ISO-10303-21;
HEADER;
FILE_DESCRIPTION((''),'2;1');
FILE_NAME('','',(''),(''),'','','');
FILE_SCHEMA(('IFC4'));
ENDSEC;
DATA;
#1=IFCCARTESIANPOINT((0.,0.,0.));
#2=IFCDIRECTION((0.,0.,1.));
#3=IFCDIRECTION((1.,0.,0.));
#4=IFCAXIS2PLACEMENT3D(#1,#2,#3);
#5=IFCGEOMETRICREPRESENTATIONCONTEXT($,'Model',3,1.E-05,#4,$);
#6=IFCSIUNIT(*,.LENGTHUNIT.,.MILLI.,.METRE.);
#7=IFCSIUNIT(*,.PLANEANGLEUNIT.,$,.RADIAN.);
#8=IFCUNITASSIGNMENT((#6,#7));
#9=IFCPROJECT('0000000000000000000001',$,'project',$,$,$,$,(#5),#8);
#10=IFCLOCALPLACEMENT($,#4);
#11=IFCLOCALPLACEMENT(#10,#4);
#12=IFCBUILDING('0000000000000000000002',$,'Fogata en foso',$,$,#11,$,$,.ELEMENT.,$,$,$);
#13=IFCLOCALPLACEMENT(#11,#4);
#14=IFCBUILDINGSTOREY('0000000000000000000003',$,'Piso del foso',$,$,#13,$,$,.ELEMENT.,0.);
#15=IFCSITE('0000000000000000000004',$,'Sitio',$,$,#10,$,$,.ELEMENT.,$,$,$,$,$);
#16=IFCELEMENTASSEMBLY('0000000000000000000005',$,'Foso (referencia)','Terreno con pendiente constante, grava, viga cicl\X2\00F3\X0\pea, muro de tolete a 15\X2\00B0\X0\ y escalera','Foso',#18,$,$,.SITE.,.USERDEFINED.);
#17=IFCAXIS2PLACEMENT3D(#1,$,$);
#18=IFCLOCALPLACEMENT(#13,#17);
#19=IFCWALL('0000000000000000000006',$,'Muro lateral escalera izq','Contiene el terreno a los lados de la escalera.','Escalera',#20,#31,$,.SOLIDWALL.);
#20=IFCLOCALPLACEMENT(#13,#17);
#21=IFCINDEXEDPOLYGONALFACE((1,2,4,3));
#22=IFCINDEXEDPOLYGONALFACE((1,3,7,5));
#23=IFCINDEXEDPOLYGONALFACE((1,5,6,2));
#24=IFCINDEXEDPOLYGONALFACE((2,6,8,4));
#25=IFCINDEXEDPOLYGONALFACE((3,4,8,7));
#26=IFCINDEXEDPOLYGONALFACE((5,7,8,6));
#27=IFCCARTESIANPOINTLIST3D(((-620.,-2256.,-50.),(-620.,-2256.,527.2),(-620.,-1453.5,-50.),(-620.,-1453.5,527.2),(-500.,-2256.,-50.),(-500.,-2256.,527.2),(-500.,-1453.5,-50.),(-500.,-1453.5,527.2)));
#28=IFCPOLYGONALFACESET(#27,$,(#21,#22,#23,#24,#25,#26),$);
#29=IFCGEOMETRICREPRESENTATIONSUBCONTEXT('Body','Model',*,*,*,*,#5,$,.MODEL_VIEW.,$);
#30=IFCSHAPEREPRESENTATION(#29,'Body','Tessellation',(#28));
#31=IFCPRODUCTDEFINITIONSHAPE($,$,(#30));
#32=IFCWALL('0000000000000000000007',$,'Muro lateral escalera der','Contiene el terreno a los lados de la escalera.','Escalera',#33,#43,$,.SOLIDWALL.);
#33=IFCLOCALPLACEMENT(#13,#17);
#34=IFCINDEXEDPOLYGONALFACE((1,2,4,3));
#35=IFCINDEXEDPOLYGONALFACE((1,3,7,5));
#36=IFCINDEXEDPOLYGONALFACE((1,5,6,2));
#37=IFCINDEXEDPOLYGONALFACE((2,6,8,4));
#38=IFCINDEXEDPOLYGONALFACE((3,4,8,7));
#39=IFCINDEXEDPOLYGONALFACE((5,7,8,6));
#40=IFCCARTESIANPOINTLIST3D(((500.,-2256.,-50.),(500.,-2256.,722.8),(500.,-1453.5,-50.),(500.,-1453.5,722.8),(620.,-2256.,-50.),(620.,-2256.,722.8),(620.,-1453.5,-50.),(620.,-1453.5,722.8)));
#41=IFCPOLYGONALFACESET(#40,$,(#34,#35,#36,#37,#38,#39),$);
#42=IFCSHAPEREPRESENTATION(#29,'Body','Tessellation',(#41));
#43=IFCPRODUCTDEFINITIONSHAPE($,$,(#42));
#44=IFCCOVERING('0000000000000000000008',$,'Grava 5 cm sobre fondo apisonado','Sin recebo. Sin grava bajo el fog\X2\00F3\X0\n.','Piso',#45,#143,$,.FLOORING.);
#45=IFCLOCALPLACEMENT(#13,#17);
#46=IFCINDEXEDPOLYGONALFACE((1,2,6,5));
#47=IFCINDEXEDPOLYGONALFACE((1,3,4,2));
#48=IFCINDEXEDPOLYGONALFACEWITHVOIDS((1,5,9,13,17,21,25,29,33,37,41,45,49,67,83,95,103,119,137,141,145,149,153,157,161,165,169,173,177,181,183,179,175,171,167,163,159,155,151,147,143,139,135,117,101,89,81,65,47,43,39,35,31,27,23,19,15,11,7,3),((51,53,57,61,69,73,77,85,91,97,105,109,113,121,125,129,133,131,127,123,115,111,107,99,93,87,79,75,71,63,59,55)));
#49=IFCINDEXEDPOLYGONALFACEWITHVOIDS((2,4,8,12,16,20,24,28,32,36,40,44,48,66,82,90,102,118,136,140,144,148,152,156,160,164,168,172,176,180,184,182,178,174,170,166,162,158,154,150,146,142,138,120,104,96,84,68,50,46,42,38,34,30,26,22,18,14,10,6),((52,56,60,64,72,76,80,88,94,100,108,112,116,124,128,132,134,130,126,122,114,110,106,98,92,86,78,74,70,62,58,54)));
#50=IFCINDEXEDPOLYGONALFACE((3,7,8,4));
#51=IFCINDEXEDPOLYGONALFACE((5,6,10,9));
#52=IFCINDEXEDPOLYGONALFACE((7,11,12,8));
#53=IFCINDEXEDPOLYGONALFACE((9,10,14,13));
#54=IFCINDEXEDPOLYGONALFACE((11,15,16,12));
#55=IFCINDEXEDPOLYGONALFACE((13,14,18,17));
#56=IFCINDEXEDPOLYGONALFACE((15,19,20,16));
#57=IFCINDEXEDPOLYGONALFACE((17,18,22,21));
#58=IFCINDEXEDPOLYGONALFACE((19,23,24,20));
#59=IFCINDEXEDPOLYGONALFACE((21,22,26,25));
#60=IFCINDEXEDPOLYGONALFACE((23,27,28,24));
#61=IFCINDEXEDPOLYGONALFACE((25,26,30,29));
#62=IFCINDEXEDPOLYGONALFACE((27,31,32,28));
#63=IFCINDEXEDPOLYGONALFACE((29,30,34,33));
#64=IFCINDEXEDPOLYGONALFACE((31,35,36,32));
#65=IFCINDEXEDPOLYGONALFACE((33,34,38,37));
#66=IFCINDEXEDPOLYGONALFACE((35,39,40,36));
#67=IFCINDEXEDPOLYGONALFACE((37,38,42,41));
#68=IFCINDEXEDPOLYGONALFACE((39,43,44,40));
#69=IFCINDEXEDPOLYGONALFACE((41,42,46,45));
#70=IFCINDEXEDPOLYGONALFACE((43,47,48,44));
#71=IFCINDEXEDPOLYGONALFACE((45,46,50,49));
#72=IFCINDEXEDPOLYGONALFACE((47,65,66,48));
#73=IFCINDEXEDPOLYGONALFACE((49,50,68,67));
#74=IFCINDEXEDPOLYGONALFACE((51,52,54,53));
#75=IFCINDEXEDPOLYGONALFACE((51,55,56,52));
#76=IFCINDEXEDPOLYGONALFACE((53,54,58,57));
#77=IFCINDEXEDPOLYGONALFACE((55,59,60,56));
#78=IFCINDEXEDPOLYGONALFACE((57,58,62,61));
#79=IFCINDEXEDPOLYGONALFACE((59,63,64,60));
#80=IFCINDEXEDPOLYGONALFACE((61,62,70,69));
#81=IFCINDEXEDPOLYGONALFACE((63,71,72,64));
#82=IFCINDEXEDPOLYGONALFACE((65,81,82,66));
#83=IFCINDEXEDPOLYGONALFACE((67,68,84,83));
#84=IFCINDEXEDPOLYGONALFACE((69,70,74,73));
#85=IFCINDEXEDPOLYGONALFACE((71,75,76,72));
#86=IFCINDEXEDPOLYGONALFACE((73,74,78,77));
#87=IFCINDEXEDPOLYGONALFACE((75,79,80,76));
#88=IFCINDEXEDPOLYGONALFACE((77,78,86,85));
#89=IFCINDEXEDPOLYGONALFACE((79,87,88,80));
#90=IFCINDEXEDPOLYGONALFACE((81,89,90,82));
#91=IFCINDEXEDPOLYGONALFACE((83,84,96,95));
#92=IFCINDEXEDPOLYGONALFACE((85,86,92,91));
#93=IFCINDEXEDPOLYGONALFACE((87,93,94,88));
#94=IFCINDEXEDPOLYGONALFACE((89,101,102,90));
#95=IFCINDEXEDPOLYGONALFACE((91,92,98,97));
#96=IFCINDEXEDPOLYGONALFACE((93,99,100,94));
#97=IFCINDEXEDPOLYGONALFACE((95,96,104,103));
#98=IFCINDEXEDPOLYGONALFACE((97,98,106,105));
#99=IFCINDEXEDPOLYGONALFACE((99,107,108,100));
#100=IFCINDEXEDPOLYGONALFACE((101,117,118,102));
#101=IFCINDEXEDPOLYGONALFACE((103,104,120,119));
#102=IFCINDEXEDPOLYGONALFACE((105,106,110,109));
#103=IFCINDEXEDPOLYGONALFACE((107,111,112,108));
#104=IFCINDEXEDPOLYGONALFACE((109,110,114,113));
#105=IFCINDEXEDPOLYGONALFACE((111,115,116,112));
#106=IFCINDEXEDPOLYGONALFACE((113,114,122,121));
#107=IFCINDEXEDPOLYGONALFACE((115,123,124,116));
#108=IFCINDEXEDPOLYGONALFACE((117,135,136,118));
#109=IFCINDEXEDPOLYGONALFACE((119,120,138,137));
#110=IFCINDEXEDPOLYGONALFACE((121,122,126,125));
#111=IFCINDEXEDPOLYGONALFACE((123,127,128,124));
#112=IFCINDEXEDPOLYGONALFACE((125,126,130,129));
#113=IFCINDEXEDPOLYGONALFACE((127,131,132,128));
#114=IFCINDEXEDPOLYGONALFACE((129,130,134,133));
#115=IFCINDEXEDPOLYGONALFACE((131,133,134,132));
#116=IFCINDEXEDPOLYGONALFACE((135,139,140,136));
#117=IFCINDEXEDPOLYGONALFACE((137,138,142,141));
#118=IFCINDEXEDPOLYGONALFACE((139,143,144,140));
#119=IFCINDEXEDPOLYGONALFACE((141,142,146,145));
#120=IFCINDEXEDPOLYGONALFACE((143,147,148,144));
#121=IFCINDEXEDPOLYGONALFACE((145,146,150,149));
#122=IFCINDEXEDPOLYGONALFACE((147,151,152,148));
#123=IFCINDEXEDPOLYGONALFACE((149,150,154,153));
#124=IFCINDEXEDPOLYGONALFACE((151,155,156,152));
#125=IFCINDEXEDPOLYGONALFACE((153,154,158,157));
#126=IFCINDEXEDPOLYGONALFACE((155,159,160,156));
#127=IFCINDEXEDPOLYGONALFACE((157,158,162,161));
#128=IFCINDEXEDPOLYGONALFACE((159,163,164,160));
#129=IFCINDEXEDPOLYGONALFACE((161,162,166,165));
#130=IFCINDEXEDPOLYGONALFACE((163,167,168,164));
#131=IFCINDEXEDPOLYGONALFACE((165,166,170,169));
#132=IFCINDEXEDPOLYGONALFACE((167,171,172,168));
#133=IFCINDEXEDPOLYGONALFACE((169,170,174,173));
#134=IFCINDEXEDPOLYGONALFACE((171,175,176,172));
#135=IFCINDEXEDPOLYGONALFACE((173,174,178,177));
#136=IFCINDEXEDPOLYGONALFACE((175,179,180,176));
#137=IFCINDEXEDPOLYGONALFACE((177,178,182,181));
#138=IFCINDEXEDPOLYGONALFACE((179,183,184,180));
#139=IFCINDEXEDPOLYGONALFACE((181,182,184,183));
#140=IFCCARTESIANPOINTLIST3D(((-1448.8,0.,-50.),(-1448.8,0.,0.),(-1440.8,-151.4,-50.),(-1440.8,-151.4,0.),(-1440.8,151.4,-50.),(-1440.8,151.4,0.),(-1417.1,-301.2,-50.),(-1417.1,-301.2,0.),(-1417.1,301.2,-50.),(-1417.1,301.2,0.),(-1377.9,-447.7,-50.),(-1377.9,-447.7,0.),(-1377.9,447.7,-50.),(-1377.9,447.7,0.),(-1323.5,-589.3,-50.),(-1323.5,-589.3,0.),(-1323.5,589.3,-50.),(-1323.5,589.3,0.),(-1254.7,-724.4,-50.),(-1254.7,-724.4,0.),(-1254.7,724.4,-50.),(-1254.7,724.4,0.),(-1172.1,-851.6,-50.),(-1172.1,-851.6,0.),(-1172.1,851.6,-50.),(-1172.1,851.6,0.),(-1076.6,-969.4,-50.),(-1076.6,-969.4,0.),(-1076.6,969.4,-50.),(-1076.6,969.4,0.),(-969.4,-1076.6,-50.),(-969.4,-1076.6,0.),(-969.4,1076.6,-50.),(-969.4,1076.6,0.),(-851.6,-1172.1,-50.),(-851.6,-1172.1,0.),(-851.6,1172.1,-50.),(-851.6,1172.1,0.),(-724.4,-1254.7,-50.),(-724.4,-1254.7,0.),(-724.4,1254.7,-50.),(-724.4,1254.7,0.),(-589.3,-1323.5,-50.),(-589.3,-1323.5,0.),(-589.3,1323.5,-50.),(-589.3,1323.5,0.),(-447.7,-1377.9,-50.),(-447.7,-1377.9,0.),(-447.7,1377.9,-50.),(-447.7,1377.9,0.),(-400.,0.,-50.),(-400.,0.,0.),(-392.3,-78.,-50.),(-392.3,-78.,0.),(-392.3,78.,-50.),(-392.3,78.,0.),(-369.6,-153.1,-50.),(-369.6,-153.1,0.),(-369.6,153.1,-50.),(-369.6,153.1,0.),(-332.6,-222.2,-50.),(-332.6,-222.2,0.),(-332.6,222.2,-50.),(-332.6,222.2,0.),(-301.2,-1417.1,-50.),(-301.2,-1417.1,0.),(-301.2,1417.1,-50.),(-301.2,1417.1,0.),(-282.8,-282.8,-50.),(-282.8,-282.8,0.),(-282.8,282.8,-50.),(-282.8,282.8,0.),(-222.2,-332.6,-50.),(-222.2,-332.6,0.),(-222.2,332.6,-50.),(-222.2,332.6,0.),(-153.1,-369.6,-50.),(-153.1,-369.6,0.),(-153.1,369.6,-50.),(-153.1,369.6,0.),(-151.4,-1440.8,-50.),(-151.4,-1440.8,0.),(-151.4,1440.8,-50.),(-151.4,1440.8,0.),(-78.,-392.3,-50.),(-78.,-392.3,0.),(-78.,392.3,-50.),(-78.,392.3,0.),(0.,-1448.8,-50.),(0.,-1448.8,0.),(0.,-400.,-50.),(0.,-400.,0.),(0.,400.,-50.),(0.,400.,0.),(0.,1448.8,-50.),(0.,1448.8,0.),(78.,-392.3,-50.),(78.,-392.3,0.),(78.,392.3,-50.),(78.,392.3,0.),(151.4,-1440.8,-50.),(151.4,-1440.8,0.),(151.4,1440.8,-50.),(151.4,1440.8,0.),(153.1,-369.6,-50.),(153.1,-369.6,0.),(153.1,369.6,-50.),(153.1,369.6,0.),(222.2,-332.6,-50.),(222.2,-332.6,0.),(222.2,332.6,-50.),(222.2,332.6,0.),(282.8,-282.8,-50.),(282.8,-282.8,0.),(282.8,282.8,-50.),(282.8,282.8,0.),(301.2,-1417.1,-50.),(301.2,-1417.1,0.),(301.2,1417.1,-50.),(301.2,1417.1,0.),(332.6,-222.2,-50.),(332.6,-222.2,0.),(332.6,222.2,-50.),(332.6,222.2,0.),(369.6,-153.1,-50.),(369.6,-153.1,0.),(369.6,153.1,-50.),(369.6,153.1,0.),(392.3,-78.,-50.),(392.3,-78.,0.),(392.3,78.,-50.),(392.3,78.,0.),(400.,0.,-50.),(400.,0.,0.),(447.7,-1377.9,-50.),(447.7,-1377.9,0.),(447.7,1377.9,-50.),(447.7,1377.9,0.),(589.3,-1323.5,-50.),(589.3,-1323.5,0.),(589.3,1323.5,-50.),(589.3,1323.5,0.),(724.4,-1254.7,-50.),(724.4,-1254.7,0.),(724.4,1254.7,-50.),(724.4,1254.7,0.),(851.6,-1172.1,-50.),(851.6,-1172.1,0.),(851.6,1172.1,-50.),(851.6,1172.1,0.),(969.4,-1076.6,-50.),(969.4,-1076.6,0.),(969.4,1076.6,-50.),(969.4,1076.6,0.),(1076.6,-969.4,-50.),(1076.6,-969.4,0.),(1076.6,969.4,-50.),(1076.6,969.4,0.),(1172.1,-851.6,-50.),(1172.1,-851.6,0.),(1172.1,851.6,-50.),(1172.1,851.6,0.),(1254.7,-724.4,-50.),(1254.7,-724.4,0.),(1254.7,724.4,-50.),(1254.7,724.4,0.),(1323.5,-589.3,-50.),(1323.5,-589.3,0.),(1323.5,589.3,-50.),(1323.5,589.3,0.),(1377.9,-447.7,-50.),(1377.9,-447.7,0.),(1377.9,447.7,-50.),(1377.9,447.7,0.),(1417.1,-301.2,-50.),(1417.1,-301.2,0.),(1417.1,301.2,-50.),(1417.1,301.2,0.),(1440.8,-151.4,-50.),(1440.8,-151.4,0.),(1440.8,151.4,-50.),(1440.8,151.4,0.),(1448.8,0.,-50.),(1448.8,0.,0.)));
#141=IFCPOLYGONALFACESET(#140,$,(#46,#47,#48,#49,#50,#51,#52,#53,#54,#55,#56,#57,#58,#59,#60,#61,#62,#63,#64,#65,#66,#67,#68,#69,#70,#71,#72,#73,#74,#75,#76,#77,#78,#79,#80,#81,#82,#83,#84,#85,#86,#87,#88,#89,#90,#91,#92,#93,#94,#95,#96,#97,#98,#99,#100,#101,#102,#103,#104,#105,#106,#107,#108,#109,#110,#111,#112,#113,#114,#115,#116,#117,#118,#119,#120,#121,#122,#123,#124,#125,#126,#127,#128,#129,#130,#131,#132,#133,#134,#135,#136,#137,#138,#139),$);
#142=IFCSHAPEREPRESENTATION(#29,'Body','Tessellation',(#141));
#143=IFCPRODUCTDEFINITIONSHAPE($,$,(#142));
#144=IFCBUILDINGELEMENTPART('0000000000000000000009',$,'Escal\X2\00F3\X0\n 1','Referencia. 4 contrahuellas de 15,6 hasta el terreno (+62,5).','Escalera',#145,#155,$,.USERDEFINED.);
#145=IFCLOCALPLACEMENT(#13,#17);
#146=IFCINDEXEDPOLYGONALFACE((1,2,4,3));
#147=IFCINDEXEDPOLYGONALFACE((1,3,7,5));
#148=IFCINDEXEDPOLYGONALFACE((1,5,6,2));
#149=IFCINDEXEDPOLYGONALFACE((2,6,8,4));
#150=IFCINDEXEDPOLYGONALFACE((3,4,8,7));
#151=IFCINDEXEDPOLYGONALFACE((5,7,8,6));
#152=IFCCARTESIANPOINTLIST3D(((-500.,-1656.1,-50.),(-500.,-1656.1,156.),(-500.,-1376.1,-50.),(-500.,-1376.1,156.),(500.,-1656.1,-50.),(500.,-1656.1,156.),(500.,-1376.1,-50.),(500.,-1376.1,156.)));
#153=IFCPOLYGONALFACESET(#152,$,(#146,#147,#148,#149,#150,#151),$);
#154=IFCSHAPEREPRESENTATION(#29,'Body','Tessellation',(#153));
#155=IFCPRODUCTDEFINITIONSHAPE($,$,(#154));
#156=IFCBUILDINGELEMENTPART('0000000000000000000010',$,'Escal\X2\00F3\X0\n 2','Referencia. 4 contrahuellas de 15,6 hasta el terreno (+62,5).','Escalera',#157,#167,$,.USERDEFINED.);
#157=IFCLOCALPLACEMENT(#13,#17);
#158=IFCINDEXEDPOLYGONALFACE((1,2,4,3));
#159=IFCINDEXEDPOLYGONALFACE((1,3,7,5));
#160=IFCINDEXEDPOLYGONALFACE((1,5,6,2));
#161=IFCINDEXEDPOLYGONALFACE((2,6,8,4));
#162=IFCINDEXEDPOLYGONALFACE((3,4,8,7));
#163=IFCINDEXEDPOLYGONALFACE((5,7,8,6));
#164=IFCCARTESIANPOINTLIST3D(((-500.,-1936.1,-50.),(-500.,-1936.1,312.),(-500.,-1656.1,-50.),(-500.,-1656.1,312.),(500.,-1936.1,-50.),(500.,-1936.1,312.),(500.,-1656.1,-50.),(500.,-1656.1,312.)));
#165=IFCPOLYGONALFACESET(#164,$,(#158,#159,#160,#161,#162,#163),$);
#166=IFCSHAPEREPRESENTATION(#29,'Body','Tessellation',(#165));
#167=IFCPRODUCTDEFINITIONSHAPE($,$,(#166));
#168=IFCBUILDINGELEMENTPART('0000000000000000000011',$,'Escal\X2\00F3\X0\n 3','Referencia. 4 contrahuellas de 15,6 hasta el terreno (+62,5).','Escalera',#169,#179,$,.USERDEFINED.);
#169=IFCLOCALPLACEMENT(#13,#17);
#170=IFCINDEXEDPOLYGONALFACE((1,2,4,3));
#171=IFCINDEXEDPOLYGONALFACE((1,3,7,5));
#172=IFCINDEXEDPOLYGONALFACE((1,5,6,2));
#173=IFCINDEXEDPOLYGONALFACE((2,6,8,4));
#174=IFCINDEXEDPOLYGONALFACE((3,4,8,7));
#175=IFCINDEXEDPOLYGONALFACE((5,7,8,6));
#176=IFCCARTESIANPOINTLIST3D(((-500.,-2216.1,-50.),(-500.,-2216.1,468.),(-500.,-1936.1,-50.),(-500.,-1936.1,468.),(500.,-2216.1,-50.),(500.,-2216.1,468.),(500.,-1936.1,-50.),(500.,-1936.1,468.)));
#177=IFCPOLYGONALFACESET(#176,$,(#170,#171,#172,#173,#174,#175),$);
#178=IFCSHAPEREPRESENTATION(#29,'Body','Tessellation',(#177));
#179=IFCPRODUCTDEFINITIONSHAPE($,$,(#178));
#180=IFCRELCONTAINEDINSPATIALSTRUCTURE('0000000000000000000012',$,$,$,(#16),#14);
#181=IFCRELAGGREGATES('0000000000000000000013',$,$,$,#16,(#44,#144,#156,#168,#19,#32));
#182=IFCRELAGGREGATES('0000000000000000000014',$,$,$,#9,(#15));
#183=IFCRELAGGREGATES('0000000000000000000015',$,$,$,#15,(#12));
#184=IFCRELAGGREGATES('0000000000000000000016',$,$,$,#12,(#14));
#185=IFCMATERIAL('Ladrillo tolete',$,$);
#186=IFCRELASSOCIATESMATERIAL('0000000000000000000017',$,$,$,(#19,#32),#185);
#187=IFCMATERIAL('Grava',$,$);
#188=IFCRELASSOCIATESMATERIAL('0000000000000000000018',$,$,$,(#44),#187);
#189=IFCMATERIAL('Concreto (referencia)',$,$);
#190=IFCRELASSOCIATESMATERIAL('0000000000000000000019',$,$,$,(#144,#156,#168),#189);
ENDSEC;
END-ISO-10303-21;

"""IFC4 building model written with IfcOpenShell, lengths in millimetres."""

from ifc_helpers import new_model, si_unit, frame, origin_with_axes, origin_2d, place, context, subcontext, project, spatial, polyline, hollow_circle, outline, extrude, material, element, aggregate, save


model = new_model("IFC4")

# Units and contexts
model_context = context("Model", 3, precision=1e-05, world=origin_with_axes())
body_context = subcontext(model_context, "Body", "Model", "MODEL_VIEW")
ifc_project = project(units=[si_unit("LENGTHUNIT", "METRE", prefix="MILLI"), si_unit("PLANEANGLEUNIT", "RADIAN")], contexts=[model_context])

# Site, building, storey
site_placement = place(None, origin_with_axes())
site = spatial("IfcSite", under=ifc_project, at=site_placement, Name="Sitio", CompositionType="ELEMENT")
building_placement = place(site_placement, origin_with_axes())
building = spatial("IfcBuilding", under=site, at=building_placement, Name="Fogata en foso", CompositionType="ELEMENT")
storey_placement = place(building_placement, origin_with_axes())
storey = spatial("IfcBuildingStorey", under=building, at=storey_placement, Name="Piso del foso", CompositionType="ELEMENT", Elevation=0.0)

# Element assembly
assembly_1_placement = place(storey_placement, origin_with_axes())
assembly_1 = element("IfcElementAssembly", 1, at=assembly_1_placement, inside=storey, Name="Foso (referencia)", Description="Terreno con pendiente constante, grava, viga ciclópea, muro de tolete a 15° y escalera", ObjectType="Foso", AssemblyPlace="SITE", PredefinedType="USERDEFINED")

# Walls
ifc_material_1 = material(Name="Ladrillo tolete")
wall_1_placement = place(storey_placement, frame((0.0, 0.0, -50.0), z_axis=(0.0, 0.0, 1.0), x_axis=(1.0, 0.0, 0.0)))
wall_1 = element("IfcWall", 2, at=wall_1_placement, material=ifc_material_1, Name="Muro lateral escalera izq", Description="Contiene el terreno a los lados de la escalera.", ObjectType="Escalera", PredefinedType="SOLIDWALL", context=body_context, shape_type="SweptSolid", body=[
    extrude(outline(polyline([(-620.0, -2256.0), (-500.0, -2256.0), (-500.0, -1453.5), (-620.0, -1453.5), (-620.0, -2256.0)])), origin_with_axes(), (0.0, 0.0, 1.0), 577.2),
])
wall_2_placement = place(storey_placement, frame((0.0, 0.0, -50.0), z_axis=(0.0, 0.0, 1.0), x_axis=(1.0, 0.0, 0.0)))
wall_2 = element("IfcWall", 3, at=wall_2_placement, material=ifc_material_1, Name="Muro lateral escalera der", Description="Contiene el terreno a los lados de la escalera.", ObjectType="Escalera", PredefinedType="SOLIDWALL", context=body_context, shape_type="SweptSolid", body=[
    extrude(outline(polyline([(500.0, -2256.0), (620.0, -2256.0), (620.0, -1453.5), (500.0, -1453.5), (500.0, -2256.0)])), origin_with_axes(), (0.0, 0.0, 1.0), 772.8),
])

# Covering
ifc_material_2 = material(Name="Grava")
covering_placement = place(storey_placement, frame((0.0, 0.0, -50.0), z_axis=(0.0, 0.0, 1.0), x_axis=(1.0, 0.0, 0.0)))
covering = element("IfcCovering", 4, at=covering_placement, material=ifc_material_2, Name="Grava 5 cm sobre fondo apisonado", Description="Sin recebo. Sin grava bajo el fogón.", ObjectType="Piso", PredefinedType="FLOORING", context=body_context, shape_type="SweptSolid", body=[
    extrude(hollow_circle(Radius=1448.8, WallThickness=1048.8, at=origin_2d()), origin_with_axes(), (0.0, 0.0, 1.0), 50.0),
])

# Building element parts
ifc_material_3 = material(Name="Concreto (referencia)")
building_element_part_1_placement = place(storey_placement, frame((0.0, 0.0, -50.0), z_axis=(0.0, 0.0, 1.0), x_axis=(1.0, 0.0, 0.0)))
building_element_part_1 = element("IfcBuildingElementPart", 5, at=building_element_part_1_placement, material=ifc_material_3, Name="Escalón 1", Description="Referencia. 4 contrahuellas de 15,6 hasta el terreno (+62,5).", ObjectType="Escalera", PredefinedType="USERDEFINED", context=body_context, shape_type="SweptSolid", body=[
    extrude(outline(polyline([(-500.0, -1656.1), (500.0, -1656.1), (500.0, -1376.1), (-500.0, -1376.1), (-500.0, -1656.1)])), origin_with_axes(), (0.0, 0.0, 1.0), 206.0),
])
building_element_part_2_placement = place(storey_placement, frame((0.0, 0.0, -50.0), z_axis=(0.0, 0.0, 1.0), x_axis=(1.0, 0.0, 0.0)))
building_element_part_2 = element("IfcBuildingElementPart", 6, at=building_element_part_2_placement, material=ifc_material_3, Name="Escalón 2", Description="Referencia. 4 contrahuellas de 15,6 hasta el terreno (+62,5).", ObjectType="Escalera", PredefinedType="USERDEFINED", context=body_context, shape_type="SweptSolid", body=[
    extrude(outline(polyline([(-500.0, -1936.1), (500.0, -1936.1), (500.0, -1656.1), (-500.0, -1656.1), (-500.0, -1936.1)])), origin_with_axes(), (0.0, 0.0, 1.0), 362.0),
])
building_element_part_3_placement = place(storey_placement, frame((0.0, 0.0, -50.0), z_axis=(0.0, 0.0, 1.0), x_axis=(1.0, 0.0, 0.0)))
building_element_part_3 = element("IfcBuildingElementPart", 7, at=building_element_part_3_placement, material=ifc_material_3, Name="Escalón 3", Description="Referencia. 4 contrahuellas de 15,6 hasta el terreno (+62,5).", ObjectType="Escalera", PredefinedType="USERDEFINED", context=body_context, shape_type="SweptSolid", body=[
    extrude(outline(polyline([(-500.0, -2216.1), (500.0, -2216.1), (500.0, -1936.1), (-500.0, -1936.1), (-500.0, -2216.1)])), origin_with_axes(), (0.0, 0.0, 1.0), 518.0),
])
aggregate(assembly_1, [covering, building_element_part_1, building_element_part_2, building_element_part_3, wall_1, wall_2])

save(model, "model.ifc")
